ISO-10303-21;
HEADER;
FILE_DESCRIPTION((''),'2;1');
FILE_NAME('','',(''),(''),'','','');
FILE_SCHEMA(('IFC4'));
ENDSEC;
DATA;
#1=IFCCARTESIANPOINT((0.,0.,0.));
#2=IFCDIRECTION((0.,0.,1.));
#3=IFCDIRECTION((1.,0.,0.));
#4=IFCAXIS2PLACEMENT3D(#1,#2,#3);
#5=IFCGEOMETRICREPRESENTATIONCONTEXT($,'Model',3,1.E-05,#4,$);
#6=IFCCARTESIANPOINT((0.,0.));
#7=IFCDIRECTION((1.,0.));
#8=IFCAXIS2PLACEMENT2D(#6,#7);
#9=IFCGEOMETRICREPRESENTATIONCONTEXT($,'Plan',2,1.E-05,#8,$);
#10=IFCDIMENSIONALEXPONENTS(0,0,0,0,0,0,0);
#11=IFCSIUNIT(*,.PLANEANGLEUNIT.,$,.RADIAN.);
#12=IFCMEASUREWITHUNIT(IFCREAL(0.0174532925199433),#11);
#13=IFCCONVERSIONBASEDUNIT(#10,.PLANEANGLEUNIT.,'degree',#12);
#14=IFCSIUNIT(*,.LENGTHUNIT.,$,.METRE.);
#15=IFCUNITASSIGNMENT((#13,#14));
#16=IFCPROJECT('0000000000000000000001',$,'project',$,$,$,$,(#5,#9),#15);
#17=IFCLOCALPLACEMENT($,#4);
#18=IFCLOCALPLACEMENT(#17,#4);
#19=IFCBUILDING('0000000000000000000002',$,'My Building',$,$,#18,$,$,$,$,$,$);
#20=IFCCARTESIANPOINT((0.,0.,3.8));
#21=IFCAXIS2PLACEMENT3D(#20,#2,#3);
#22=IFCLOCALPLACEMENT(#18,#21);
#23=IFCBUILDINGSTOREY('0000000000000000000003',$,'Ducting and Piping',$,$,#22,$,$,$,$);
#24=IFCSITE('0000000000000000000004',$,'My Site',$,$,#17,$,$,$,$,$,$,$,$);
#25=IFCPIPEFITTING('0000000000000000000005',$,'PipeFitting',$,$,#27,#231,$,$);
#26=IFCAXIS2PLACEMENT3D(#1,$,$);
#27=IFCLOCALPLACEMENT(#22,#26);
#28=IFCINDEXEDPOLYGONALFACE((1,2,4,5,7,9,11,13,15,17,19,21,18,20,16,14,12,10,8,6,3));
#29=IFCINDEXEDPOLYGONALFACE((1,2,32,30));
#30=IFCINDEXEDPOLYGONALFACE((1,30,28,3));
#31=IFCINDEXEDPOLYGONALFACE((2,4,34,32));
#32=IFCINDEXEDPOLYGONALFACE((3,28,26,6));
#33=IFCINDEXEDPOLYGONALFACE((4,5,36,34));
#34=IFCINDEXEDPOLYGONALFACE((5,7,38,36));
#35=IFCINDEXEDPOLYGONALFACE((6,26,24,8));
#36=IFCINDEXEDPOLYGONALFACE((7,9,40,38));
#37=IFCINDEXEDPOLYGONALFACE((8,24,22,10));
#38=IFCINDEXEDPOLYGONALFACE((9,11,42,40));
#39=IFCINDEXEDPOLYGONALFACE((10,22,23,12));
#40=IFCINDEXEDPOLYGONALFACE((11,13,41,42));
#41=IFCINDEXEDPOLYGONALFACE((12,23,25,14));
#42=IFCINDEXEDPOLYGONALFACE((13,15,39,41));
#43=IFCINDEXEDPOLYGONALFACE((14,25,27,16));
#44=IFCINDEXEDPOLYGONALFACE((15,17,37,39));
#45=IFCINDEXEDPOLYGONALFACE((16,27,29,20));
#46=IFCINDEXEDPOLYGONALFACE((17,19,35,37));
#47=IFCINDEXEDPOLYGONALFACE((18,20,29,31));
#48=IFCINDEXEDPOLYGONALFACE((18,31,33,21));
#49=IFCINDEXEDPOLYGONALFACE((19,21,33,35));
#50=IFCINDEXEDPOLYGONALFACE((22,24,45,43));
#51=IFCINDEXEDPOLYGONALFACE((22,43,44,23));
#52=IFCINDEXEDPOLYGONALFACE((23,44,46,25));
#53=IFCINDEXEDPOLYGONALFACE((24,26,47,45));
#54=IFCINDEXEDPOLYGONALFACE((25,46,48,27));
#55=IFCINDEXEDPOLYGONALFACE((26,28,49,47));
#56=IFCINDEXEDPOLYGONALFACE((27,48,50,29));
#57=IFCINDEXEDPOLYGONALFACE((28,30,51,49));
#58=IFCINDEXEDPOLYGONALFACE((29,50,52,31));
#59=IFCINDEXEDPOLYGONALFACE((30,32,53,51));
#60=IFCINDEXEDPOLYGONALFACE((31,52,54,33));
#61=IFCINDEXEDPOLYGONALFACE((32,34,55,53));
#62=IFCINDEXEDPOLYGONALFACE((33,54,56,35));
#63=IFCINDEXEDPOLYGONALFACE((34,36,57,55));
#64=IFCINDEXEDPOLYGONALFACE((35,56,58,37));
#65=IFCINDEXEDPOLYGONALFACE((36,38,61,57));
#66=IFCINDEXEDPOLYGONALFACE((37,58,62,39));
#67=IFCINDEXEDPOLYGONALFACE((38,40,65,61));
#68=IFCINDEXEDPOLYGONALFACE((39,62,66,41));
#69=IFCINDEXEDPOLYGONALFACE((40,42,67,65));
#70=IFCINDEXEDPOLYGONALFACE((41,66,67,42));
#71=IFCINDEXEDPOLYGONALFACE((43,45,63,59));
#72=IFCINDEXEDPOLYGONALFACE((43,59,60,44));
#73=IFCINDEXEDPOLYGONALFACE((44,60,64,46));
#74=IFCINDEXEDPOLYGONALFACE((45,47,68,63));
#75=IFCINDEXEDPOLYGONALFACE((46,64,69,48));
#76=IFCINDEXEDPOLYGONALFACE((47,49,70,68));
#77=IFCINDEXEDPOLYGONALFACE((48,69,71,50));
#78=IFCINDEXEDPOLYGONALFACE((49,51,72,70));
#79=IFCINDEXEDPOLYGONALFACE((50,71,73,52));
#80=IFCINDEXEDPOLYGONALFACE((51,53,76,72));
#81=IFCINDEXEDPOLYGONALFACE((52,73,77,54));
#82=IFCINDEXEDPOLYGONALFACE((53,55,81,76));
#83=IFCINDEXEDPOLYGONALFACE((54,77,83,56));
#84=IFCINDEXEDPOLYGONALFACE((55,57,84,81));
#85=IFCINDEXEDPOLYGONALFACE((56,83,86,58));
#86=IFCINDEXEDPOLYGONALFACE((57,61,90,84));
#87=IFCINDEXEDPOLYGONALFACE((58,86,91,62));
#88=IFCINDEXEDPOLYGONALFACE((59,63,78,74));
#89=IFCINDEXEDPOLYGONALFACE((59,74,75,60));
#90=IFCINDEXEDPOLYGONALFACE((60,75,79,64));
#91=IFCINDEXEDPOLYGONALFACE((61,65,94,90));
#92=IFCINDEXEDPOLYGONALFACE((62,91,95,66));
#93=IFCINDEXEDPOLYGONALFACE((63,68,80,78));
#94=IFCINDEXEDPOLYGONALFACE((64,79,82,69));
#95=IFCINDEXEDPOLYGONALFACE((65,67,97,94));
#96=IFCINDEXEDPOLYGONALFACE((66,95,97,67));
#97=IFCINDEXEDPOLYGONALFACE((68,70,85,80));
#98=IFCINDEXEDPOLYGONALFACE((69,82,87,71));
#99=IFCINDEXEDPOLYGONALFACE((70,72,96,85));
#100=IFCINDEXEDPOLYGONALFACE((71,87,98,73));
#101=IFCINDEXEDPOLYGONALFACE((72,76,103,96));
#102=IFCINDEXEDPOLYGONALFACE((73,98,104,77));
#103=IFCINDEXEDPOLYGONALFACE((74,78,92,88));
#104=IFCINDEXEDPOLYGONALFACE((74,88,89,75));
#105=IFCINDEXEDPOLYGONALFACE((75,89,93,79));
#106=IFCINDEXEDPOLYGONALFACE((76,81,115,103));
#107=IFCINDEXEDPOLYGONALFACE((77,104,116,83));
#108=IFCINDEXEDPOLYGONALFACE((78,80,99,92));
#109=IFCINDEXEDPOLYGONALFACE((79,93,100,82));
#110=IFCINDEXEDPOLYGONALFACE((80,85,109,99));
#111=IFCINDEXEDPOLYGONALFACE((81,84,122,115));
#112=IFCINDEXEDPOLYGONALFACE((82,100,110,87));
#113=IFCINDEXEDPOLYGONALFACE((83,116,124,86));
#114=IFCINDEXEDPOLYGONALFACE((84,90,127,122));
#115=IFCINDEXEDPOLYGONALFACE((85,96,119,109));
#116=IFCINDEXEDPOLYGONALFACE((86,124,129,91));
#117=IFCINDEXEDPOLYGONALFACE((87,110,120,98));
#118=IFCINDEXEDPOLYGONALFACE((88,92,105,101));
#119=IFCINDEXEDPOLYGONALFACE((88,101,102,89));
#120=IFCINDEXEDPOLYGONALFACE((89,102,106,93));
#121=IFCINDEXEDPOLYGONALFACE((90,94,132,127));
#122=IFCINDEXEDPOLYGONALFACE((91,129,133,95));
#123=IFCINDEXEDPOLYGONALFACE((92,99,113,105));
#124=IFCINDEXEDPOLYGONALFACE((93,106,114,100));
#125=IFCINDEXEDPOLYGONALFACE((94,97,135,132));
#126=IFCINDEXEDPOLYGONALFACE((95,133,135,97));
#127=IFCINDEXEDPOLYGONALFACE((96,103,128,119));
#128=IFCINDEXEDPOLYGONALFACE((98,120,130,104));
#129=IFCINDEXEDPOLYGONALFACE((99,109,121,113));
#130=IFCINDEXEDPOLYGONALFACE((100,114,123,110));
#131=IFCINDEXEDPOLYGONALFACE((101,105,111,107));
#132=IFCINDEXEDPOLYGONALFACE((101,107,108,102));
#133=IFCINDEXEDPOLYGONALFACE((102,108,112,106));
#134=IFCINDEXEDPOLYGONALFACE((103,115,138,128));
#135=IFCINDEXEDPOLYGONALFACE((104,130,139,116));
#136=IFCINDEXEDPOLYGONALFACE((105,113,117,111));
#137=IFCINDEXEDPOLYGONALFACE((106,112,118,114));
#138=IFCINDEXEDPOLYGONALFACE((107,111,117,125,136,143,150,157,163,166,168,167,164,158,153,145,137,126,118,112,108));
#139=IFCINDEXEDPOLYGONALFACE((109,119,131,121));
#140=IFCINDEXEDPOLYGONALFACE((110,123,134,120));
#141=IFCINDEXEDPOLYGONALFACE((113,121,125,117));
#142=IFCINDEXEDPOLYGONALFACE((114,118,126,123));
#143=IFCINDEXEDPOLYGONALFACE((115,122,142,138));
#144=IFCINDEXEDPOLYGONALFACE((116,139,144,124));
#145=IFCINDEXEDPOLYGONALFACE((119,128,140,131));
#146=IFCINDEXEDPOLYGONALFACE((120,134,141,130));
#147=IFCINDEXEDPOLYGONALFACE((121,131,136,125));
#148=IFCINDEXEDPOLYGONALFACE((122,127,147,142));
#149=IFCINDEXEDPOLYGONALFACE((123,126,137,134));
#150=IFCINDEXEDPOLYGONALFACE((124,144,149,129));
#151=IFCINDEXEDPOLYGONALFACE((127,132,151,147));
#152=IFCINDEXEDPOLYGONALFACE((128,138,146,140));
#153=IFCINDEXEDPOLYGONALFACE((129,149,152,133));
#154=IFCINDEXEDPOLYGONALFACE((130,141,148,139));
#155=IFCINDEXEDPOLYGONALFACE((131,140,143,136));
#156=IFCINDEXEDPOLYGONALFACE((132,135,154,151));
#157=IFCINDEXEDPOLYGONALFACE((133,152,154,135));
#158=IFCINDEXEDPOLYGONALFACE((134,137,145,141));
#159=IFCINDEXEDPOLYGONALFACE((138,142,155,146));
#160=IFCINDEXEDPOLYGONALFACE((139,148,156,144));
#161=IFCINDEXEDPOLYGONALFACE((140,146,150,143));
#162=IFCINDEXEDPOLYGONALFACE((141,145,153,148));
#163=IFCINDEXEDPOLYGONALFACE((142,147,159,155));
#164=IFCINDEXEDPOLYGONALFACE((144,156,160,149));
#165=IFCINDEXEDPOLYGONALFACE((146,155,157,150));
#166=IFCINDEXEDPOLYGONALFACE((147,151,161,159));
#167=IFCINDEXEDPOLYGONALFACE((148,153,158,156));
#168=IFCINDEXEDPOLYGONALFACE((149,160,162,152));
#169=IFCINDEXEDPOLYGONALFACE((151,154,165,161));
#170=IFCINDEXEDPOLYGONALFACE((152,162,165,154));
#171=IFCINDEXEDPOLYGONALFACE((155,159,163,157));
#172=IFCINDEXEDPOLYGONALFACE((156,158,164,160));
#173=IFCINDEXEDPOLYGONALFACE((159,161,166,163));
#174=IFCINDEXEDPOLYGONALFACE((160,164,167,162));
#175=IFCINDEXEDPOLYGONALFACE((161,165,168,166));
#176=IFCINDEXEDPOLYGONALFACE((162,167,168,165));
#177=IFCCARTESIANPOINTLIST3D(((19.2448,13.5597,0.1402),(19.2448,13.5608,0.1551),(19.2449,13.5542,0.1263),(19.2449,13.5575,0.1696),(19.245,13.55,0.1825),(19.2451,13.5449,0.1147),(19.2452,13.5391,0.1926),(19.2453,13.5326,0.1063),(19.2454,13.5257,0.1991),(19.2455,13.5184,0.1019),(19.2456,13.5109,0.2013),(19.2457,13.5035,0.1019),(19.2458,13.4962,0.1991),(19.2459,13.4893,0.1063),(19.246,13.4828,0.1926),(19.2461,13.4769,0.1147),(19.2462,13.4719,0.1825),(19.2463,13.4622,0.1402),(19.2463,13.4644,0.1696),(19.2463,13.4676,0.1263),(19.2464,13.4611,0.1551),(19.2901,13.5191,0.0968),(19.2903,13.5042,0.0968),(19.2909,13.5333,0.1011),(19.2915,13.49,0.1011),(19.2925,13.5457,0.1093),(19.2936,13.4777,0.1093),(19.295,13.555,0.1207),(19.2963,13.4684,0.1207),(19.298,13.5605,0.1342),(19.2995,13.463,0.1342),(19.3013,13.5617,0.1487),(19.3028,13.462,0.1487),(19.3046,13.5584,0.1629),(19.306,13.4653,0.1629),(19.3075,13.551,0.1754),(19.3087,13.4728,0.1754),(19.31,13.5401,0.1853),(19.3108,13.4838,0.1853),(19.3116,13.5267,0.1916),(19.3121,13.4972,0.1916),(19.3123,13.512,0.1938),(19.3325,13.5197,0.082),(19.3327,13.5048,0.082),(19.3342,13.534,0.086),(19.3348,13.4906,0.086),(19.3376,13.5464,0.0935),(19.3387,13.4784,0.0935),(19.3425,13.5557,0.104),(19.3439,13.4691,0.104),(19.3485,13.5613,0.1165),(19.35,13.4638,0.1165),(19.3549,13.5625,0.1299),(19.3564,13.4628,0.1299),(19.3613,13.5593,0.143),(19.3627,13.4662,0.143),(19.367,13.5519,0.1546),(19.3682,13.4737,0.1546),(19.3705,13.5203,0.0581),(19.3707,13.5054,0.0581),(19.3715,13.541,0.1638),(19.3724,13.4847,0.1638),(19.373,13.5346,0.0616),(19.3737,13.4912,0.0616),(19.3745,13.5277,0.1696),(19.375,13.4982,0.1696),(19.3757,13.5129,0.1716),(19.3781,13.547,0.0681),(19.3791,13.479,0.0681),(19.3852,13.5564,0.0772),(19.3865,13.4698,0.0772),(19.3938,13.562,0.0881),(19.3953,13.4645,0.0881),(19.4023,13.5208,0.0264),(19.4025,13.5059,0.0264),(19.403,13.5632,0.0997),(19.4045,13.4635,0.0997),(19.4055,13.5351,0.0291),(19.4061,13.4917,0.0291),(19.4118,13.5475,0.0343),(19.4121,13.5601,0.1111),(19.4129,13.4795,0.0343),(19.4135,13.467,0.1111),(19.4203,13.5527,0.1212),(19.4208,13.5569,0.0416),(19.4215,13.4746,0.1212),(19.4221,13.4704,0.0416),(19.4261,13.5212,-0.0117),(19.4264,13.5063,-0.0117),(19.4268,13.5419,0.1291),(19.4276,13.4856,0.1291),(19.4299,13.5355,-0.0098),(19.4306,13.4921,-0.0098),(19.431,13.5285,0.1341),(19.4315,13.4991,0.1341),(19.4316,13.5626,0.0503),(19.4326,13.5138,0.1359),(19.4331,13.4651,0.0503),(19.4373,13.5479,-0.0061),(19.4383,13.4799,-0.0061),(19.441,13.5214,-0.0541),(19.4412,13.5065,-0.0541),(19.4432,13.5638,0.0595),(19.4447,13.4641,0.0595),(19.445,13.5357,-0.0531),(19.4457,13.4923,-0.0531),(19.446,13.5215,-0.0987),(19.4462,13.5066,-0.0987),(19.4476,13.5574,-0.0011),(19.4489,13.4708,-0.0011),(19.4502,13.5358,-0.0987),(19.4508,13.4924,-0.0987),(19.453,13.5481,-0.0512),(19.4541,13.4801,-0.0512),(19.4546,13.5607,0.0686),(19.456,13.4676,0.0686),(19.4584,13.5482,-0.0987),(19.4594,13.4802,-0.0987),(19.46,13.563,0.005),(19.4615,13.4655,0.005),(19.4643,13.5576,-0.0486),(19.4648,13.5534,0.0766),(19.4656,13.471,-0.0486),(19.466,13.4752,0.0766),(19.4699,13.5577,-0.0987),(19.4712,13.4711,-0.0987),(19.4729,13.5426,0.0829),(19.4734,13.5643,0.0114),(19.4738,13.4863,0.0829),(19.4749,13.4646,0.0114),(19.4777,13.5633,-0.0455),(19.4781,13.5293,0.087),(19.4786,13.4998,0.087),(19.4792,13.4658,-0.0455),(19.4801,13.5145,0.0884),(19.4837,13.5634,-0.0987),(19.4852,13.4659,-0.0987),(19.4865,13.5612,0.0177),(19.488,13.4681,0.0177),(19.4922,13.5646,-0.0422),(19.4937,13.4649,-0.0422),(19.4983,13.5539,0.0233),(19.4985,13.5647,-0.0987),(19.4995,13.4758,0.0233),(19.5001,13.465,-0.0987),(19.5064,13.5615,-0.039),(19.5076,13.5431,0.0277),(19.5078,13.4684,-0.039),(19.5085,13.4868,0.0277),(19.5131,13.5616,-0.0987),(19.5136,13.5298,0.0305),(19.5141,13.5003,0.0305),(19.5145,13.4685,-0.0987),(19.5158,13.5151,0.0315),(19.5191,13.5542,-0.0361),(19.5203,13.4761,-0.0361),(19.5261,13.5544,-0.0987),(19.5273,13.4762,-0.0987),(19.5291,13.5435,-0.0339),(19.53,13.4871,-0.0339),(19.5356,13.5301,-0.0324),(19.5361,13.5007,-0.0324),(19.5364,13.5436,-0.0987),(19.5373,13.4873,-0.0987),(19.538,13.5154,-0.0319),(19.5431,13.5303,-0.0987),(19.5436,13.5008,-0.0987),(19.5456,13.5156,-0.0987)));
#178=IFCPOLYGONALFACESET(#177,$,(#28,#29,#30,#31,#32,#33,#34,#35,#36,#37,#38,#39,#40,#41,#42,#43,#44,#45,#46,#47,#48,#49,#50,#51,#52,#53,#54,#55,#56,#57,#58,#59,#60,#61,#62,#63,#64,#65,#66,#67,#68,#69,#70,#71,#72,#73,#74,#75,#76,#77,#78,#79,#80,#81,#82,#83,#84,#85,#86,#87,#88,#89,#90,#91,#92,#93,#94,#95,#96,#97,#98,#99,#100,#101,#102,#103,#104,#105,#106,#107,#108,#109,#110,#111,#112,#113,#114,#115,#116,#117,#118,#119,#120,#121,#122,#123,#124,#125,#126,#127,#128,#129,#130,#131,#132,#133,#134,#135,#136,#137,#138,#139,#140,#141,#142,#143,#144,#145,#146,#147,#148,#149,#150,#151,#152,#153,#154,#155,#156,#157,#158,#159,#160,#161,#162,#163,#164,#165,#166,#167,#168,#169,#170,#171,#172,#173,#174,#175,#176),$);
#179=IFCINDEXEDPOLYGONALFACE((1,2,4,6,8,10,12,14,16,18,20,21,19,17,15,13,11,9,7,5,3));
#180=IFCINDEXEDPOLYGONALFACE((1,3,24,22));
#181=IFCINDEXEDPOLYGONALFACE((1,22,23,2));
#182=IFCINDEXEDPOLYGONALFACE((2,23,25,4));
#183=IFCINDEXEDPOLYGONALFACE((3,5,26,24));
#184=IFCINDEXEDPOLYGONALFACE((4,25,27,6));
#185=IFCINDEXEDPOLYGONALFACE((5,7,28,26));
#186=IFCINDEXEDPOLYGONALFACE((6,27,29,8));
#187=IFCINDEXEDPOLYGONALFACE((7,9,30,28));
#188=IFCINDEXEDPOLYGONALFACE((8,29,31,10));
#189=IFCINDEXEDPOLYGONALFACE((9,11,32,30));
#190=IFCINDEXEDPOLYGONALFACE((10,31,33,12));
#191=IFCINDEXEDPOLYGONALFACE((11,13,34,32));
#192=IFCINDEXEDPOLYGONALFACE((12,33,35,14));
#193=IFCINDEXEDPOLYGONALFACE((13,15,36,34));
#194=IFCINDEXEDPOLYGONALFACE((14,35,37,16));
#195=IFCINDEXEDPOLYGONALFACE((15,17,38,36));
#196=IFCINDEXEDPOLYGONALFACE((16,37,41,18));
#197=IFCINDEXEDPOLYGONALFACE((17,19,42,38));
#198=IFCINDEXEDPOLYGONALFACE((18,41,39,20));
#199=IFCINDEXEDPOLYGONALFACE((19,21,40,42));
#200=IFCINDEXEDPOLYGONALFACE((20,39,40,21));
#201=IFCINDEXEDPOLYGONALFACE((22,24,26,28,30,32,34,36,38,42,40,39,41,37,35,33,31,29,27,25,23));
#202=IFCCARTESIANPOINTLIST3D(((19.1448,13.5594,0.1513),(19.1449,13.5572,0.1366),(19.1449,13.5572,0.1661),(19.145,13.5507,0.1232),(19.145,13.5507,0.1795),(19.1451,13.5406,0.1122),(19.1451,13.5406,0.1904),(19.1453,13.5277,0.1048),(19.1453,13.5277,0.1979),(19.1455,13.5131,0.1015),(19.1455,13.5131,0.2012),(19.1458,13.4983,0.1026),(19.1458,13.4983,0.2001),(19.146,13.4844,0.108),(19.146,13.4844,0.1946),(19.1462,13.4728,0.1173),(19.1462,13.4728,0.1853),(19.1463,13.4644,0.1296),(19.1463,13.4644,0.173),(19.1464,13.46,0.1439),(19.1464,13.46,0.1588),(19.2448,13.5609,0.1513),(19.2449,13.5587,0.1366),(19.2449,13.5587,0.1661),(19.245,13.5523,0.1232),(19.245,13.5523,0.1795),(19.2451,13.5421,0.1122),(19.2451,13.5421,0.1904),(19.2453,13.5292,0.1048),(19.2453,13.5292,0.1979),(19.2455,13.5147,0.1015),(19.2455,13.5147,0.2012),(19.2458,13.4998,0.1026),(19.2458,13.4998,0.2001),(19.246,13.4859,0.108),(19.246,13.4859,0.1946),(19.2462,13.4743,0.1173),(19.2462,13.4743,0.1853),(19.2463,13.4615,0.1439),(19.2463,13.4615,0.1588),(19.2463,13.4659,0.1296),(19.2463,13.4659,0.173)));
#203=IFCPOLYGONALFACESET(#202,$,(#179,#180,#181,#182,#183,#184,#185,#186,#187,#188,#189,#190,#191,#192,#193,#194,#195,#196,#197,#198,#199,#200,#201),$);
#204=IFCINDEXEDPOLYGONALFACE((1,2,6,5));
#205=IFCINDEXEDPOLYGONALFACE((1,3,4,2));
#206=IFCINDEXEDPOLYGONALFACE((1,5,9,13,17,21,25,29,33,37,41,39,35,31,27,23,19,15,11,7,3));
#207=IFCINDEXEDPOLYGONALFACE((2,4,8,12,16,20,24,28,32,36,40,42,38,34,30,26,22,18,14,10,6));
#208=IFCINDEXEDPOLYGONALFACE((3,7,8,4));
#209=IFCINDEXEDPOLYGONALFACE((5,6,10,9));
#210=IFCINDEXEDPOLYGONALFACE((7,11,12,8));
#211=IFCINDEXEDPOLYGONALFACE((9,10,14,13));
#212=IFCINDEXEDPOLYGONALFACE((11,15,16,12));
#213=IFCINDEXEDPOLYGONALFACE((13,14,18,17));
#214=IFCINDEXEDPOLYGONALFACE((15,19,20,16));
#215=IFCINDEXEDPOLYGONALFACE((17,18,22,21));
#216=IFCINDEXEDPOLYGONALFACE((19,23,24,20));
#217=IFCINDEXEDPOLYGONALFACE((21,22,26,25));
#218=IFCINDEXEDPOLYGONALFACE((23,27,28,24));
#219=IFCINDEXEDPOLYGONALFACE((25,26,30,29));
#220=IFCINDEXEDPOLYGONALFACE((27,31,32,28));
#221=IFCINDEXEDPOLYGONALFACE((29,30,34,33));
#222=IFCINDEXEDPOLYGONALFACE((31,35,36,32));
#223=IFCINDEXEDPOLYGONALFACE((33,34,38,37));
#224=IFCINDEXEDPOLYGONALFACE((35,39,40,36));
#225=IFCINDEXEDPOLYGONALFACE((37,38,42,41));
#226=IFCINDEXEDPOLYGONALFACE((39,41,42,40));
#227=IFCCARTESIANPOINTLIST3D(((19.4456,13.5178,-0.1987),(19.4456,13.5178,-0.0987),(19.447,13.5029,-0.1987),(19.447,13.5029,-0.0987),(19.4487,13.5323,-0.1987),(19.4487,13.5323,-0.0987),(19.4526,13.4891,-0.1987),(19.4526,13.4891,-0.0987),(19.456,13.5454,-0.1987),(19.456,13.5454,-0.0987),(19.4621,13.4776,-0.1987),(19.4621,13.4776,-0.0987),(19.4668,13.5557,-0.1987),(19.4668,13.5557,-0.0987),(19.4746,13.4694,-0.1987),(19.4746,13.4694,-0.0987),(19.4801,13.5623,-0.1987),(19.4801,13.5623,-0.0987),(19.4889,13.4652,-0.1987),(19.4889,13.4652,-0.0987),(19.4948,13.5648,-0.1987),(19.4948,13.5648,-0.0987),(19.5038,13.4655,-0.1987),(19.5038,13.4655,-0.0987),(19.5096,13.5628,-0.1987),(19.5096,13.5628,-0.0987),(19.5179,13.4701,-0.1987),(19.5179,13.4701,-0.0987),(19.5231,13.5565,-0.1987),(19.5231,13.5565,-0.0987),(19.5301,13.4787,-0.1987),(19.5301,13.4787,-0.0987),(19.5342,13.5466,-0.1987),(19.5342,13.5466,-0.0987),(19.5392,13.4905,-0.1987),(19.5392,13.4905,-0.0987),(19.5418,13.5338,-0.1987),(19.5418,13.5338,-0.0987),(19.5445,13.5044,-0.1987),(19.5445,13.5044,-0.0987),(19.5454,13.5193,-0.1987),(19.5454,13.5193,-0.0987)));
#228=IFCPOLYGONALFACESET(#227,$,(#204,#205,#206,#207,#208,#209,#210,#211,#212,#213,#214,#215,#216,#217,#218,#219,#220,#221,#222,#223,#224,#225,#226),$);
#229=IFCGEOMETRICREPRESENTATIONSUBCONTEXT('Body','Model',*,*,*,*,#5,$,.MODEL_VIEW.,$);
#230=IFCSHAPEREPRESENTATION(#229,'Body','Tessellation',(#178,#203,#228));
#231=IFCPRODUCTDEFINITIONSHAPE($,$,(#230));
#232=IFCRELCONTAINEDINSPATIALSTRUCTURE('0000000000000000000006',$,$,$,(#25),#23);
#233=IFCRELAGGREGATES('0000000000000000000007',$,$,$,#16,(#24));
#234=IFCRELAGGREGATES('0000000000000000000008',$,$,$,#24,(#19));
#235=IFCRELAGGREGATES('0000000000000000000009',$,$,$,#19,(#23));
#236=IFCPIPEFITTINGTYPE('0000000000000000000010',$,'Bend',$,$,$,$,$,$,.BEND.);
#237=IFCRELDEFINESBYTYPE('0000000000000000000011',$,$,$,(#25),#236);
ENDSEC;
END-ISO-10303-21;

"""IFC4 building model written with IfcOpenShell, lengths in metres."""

from ifc_helpers import new_model, entity, si_unit, converted_unit, frame, origin_with_axes, origin_2d_with_axis, place, context, subcontext, project, spatial, circle, extrude, source, transform, mapped, type_object, type_shapes, element, save


model = new_model("IFC4")

# Units and contexts
model_context = context("Model", 3, precision=1e-05, world=origin_with_axes())
plan_context = context("Plan", 2, precision=1e-05, world=origin_2d_with_axis())
body_context = subcontext(model_context, "Body", "Model", "MODEL_VIEW")
ifc_project = project(units=[converted_unit("PLANEANGLEUNIT", "degree", entity("IfcReal", 0.0174532925199433), si_unit("PLANEANGLEUNIT", "RADIAN"), dimensions=[0, 0, 0, 0, 0, 0, 0]), si_unit("LENGTHUNIT", "METRE")], contexts=[model_context, plan_context])

# Site, building, storey
site_placement = place(None, origin_with_axes())
site = spatial("IfcSite", under=ifc_project, at=site_placement, Name="My Site")
building_placement = place(site_placement, origin_with_axes())
building = spatial("IfcBuilding", under=site, at=building_placement, Name="My Building")
storey_placement = place(building_placement, frame((0.0, 0.0, 3.8), z_axis=(0.0, 0.0, 1.0), x_axis=(1.0, 0.0, 0.0)))
storey = spatial("IfcBuildingStorey", under=building, at=storey_placement, Name="Ducting and Piping")

# Pipe fitting
pipe_fitting_type = type_object("IfcPipeFittingType", Name="Bend", PredefinedType="BEND")
shared_shape = source(origin_with_axes(), body_context, "Body", "SolidModel", [
    entity("IfcSweptDiskSolid", entity("IfcIndexedPolyCurve", entity("IfcCartesianPointList3D", [[0.0, 0.0, 0.1], [0.0, -0.0732, 0.2768], [0.0, -0.25, 0.35]]), [entity("IfcArcIndex", [1, 2, 3])]), 0.05),
    extrude(circle(Radius=0.05), origin_with_axes(), (0.0, 0.0, 1.0), 0.1),
    extrude(circle(Radius=0.05), frame((0.0, -0.25, 0.35), z_axis=(0.0, -1.0, 0.0), x_axis=(1.0, 0.0, 0.0)), (0.0, 0.0, 1.0), 0.1),
])
type_shapes(pipe_fitting_type, [shared_shape])
for number, where, z_axis, x_axis, name in (
    (1, (19.1456, 13.5094, 0.1513), (0.999882, 0.015371, 0.0), (-0.015371, 0.999882, 0.0), "PipeFitting"),
):
    element("IfcPipeFitting", number, at=place(storey_placement, frame(where, z_axis=z_axis, x_axis=x_axis)), inside=storey, type_object=pipe_fitting_type, Name=name, context=body_context, shape_type="MappedRepresentation", body=[
        mapped(shared_shape, transform((0.0, 0.0, 0.0), x_axis=(1.0, 0.0, 0.0), y_axis=(0.0, 1.0, 0.0), z_axis=(0.0, 0.0, 1.0), scale=1.0)),
    ])

save(model, "model.ifc")
